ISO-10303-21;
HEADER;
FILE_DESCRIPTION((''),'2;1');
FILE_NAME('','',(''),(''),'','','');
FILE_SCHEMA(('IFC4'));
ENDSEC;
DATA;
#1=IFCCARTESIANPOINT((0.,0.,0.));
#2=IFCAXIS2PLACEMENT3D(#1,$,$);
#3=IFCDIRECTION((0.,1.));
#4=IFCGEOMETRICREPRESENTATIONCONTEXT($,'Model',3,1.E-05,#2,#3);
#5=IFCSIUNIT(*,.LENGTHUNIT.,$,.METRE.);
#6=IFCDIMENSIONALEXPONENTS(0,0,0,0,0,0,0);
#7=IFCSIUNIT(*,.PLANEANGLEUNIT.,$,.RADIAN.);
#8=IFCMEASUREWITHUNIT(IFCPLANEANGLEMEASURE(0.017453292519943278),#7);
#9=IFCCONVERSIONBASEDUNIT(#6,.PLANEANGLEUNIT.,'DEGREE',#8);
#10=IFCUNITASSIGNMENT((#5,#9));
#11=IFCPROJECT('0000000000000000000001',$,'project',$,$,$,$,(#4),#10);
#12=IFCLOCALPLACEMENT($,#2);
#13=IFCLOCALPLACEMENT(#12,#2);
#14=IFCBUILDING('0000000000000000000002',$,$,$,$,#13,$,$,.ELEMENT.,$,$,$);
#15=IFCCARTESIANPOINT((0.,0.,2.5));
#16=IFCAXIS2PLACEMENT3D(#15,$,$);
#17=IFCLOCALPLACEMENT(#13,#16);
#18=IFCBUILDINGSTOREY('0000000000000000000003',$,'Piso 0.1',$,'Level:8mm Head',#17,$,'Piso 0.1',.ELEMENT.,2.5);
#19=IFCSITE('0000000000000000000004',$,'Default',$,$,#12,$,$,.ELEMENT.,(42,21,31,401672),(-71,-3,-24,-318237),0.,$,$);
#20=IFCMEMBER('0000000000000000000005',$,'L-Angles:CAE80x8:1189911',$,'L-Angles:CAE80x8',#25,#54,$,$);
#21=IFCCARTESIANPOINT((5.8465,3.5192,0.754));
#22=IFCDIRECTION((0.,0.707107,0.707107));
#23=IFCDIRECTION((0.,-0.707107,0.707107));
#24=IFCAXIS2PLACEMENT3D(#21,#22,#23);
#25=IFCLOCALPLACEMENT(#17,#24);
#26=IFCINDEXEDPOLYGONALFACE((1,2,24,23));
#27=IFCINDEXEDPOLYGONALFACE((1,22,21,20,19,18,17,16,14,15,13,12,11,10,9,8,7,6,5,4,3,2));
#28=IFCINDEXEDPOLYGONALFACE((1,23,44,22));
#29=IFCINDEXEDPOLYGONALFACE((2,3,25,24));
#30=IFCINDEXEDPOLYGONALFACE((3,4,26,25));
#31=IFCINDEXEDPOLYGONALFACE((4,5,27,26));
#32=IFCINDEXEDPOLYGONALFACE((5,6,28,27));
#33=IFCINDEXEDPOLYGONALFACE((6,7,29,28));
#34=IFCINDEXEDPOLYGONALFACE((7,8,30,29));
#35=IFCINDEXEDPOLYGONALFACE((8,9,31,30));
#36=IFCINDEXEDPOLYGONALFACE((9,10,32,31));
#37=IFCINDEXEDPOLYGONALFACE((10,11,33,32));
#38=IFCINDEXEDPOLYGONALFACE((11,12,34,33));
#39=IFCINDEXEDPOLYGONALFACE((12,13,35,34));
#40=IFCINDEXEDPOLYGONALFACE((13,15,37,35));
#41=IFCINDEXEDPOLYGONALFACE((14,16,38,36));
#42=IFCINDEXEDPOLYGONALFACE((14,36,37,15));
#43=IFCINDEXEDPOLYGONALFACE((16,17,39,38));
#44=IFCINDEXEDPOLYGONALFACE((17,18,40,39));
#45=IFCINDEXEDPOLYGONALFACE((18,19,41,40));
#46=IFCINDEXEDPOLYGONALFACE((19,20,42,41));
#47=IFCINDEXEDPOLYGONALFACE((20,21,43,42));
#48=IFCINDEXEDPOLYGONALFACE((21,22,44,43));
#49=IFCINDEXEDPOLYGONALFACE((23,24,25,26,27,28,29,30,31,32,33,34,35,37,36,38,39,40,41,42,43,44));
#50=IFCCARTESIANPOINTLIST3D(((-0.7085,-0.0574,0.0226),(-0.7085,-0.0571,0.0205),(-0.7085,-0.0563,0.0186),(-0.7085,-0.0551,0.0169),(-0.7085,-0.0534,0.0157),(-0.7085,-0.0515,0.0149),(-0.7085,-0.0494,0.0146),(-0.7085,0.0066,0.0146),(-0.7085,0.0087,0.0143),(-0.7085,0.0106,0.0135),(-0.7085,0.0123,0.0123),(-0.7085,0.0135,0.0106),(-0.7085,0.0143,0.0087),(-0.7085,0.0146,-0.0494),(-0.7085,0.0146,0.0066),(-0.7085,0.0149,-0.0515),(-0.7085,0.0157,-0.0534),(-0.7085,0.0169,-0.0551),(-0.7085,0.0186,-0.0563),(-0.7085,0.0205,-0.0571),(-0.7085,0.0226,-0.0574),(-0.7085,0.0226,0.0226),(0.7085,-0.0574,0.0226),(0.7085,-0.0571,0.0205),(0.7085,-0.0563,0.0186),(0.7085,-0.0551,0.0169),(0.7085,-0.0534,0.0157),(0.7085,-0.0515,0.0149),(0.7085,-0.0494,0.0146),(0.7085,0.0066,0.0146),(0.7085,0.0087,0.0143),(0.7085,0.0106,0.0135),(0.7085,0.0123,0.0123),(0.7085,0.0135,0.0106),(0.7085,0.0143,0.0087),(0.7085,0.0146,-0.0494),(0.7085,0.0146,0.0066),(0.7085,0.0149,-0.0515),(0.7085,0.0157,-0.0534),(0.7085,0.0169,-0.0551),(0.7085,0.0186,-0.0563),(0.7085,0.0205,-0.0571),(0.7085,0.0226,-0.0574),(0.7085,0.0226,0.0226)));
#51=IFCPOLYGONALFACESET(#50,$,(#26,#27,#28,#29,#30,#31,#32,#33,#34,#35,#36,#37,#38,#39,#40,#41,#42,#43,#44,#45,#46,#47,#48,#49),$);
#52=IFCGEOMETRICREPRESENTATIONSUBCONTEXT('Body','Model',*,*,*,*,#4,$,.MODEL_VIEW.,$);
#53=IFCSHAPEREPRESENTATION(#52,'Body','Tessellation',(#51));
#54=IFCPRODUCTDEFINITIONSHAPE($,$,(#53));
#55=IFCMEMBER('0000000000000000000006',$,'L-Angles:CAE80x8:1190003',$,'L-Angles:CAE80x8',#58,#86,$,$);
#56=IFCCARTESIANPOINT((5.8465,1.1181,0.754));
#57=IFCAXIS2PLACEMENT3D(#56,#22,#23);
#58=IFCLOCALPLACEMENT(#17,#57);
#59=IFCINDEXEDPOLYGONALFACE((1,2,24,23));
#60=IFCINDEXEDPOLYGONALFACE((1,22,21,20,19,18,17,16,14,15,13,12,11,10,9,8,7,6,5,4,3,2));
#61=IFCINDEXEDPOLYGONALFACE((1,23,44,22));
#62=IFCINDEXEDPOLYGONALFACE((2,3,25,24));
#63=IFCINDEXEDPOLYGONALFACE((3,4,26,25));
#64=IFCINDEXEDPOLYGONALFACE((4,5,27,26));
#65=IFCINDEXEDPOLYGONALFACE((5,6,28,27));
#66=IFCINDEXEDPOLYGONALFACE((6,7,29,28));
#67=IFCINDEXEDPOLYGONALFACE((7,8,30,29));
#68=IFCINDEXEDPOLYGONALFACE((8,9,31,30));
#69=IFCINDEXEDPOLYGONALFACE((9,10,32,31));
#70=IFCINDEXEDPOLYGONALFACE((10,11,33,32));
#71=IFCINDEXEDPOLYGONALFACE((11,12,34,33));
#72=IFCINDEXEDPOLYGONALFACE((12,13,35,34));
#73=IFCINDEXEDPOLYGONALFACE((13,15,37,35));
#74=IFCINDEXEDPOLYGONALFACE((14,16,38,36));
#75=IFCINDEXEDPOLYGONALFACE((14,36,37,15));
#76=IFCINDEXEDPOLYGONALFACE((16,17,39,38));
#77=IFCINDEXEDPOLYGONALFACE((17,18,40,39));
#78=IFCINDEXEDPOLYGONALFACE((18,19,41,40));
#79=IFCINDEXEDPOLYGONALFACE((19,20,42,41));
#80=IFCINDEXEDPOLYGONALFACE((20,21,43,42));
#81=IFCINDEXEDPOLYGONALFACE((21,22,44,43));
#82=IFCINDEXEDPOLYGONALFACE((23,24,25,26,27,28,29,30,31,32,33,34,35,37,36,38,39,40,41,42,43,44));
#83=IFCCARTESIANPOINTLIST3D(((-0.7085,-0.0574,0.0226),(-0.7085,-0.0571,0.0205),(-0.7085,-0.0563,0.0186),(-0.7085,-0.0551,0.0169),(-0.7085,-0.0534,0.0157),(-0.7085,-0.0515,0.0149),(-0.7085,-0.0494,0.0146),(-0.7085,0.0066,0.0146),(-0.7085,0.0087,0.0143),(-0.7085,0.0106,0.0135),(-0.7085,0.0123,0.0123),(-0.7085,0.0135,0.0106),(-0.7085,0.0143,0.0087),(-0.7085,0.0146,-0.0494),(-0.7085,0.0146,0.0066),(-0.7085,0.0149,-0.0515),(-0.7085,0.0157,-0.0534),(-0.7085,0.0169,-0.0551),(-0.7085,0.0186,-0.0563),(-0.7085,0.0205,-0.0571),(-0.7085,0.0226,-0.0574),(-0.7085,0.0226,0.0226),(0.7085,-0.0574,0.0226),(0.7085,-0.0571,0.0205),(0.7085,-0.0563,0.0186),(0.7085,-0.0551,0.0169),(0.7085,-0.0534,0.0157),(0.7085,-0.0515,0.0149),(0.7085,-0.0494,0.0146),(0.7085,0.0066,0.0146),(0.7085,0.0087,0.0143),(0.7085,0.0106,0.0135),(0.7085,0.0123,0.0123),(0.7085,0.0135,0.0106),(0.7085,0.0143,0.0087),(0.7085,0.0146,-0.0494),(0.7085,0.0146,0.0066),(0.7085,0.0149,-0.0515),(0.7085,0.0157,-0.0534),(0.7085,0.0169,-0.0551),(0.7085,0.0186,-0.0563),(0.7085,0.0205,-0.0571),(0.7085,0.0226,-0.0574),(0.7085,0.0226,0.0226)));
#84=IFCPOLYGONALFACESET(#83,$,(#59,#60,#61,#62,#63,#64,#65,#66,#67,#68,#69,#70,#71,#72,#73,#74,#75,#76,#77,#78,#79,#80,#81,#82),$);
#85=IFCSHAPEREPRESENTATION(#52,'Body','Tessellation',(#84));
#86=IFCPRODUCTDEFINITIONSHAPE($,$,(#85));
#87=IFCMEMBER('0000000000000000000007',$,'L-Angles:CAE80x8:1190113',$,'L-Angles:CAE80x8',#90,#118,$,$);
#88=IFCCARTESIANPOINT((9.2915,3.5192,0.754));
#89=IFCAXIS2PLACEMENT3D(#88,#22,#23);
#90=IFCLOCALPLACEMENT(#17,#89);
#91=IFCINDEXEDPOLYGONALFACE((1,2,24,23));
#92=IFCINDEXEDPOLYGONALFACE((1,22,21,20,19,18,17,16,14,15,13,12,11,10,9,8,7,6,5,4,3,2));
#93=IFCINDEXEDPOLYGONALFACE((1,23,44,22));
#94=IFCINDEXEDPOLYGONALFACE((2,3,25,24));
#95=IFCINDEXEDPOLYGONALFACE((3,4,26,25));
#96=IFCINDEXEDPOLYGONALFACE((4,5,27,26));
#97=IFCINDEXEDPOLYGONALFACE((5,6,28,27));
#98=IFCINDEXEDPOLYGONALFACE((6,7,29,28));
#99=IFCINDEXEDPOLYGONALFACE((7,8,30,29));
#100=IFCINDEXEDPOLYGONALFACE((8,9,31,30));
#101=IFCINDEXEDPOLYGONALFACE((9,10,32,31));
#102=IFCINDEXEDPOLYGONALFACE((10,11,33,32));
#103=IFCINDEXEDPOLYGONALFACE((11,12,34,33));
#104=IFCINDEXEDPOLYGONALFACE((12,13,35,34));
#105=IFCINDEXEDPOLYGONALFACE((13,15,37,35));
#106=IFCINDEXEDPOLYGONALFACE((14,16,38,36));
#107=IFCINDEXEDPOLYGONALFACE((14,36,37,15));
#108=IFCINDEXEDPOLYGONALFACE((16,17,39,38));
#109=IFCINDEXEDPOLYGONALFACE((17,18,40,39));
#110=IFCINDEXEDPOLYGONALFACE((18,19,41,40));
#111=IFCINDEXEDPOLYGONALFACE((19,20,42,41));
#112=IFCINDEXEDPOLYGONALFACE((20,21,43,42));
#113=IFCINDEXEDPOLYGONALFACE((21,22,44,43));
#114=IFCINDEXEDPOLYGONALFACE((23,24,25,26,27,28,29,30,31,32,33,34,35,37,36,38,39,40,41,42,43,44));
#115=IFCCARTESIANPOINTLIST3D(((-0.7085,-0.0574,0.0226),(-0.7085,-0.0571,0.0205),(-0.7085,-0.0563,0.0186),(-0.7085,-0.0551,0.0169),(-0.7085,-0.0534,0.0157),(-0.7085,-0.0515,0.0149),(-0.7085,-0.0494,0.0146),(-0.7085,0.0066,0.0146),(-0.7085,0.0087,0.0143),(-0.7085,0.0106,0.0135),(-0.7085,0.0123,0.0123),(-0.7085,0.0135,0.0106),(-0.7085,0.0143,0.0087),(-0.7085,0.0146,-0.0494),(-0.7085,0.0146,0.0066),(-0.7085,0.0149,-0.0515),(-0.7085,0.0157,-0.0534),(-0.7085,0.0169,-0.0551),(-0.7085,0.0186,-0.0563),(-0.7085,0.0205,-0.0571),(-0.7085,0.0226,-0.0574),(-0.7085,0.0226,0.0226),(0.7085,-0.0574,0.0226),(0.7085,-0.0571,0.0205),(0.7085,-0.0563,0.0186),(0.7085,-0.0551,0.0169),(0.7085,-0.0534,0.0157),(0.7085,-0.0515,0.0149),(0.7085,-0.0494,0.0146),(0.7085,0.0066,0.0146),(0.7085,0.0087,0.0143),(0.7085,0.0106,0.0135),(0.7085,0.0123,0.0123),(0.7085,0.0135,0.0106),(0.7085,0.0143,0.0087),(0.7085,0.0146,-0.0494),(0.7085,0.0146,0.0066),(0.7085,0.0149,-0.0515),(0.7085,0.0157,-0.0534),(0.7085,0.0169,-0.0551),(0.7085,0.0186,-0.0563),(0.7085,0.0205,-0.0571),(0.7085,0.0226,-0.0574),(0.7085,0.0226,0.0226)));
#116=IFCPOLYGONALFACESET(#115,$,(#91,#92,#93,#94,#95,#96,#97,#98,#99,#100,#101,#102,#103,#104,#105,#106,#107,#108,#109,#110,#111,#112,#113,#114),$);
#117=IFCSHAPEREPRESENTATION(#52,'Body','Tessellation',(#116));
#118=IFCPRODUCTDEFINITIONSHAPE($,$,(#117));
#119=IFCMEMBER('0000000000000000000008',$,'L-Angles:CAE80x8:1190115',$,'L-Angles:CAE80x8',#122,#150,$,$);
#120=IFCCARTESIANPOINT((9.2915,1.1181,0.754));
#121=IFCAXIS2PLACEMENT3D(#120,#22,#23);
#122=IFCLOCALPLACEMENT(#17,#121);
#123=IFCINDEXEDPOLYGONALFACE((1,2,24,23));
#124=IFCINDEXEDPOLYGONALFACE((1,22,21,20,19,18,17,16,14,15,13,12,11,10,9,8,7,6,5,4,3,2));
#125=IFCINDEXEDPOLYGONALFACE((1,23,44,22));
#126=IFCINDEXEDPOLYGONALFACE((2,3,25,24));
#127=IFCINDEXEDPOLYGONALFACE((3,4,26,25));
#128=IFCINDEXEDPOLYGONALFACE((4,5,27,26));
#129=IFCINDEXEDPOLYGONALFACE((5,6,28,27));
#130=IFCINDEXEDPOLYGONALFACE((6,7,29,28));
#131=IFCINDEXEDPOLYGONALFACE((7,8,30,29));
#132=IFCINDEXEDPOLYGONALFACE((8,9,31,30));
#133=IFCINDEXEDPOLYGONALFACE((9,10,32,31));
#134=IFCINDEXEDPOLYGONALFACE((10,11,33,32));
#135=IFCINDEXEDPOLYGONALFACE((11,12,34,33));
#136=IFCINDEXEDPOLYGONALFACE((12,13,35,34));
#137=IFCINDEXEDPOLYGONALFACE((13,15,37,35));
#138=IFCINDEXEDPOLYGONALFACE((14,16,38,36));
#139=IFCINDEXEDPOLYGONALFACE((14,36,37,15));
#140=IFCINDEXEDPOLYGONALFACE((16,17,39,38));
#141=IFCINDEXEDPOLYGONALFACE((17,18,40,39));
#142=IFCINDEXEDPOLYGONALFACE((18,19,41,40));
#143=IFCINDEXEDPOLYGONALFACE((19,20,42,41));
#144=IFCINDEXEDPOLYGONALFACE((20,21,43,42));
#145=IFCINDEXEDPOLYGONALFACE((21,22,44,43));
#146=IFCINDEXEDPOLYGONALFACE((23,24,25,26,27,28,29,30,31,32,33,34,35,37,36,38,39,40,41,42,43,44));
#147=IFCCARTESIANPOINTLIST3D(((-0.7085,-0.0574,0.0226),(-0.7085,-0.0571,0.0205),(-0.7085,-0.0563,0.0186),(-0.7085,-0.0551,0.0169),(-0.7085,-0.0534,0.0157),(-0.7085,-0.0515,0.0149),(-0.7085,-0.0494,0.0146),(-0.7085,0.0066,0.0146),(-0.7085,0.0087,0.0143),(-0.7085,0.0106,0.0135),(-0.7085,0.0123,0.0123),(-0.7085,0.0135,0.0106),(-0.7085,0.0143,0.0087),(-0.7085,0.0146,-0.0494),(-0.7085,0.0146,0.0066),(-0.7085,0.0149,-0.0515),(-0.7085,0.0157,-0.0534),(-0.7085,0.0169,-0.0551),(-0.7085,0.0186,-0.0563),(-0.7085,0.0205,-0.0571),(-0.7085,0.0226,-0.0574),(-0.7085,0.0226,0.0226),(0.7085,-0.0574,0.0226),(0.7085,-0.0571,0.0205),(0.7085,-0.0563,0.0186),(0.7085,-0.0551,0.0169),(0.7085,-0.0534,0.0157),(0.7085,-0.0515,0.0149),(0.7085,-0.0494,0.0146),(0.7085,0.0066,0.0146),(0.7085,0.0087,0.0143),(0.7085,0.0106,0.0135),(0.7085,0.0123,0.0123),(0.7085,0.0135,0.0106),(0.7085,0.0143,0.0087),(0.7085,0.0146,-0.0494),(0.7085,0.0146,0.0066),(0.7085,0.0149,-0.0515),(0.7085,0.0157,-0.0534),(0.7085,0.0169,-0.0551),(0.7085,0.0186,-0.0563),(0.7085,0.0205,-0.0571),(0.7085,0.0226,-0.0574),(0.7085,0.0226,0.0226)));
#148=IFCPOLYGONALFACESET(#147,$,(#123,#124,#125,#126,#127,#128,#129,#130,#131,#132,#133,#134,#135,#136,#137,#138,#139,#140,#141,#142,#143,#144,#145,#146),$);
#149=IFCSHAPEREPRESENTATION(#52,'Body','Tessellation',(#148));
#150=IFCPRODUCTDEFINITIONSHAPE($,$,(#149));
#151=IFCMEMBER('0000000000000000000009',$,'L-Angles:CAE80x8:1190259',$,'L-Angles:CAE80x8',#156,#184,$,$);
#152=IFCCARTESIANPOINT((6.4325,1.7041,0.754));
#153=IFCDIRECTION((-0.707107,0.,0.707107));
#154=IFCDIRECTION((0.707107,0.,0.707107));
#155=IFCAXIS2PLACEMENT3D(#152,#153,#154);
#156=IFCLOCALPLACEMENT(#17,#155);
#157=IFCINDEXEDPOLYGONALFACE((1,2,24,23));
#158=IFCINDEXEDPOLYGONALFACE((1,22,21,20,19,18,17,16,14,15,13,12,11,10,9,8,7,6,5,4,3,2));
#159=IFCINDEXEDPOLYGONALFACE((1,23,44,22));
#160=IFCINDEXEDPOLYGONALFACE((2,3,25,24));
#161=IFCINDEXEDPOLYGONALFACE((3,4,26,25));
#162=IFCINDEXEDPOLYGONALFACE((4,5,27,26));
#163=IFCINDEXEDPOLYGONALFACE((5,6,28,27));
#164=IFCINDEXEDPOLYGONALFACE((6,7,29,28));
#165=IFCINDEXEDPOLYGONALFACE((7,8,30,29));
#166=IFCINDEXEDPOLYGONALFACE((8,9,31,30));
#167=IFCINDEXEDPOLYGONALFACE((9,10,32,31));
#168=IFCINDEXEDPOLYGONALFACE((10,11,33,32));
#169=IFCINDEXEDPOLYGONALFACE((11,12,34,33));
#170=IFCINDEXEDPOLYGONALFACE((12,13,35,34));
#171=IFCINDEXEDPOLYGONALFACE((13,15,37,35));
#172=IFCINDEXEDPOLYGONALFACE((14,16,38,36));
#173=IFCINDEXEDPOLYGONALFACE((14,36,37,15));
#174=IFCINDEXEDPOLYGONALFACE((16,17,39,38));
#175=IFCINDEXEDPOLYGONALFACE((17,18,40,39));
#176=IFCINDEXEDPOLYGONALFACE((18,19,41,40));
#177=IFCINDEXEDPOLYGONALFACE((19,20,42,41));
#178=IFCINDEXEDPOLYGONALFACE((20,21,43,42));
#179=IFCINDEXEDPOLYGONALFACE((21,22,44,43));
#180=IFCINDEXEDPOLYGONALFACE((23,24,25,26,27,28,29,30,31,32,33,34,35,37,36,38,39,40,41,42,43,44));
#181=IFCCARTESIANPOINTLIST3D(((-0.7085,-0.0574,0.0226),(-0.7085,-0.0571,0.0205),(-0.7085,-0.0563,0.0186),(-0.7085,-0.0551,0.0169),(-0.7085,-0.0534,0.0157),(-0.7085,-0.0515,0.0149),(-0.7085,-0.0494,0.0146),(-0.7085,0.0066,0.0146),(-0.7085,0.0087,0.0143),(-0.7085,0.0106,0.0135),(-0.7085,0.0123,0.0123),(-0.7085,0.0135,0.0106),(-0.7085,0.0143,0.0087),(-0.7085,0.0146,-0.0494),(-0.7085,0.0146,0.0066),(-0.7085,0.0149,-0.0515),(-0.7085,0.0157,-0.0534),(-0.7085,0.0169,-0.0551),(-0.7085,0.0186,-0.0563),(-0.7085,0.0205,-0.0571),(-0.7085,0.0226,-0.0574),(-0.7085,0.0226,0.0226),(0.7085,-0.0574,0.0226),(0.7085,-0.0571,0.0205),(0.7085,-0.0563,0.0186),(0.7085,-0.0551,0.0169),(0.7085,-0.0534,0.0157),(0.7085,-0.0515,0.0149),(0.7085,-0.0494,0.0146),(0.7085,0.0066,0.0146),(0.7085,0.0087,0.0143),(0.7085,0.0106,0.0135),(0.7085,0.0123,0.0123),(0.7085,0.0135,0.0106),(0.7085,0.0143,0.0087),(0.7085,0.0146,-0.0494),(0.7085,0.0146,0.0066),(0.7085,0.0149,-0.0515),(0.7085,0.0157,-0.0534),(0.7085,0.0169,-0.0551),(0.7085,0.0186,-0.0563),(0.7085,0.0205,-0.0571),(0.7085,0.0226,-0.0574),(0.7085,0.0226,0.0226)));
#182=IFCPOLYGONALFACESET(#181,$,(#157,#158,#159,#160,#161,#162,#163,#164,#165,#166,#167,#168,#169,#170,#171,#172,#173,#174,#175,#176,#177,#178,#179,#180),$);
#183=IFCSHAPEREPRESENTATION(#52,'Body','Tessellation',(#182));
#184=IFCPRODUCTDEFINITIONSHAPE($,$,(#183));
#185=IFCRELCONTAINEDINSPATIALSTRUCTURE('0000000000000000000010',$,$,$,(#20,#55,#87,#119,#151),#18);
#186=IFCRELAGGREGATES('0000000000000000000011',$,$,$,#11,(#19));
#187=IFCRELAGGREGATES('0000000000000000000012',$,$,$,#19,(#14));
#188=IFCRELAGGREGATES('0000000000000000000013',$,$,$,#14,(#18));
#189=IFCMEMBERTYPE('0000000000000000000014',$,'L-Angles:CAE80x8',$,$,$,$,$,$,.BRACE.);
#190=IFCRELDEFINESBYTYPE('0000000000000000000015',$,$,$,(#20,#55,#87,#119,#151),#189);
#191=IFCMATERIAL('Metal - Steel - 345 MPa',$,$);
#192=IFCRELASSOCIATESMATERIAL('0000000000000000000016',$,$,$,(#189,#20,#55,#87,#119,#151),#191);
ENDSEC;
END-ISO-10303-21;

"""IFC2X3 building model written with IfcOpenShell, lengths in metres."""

from ifc_helpers import new_model, entity, si_unit, converted_unit, direction, frame, frame_2d, origin, place, context, subcontext, project, spatial, polyline, circle_curve, parameter, trimmed, segment, composite_curve, outline, extrude, source, transform, mapped, material, type_object, type_shapes, element, save


model = new_model("IFC2X3")

# Units and contexts
model_context = context("Model", 3, precision=1e-05, world=origin(), true_north=direction((0.0, 1.0)))
body_context = subcontext(model_context, "Body", "Model", "MODEL_VIEW")
ifc_project = project(units=[si_unit("LENGTHUNIT", "METRE"), converted_unit("PLANEANGLEUNIT", "DEGREE", entity("IfcPlaneAngleMeasure", 0.017453292519943278), si_unit("PLANEANGLEUNIT", "RADIAN"), dimensions=[0, 0, 0, 0, 0, 0, 0])], contexts=[model_context])

# Site, building, storey
site_placement = place(None, origin())
site = spatial("IfcSite", under=ifc_project, at=site_placement, Name="Default", CompositionType="ELEMENT", RefLatitude=(42, 21, 31, 401672), RefLongitude=(-71, -3, -24, -318237), RefElevation=0.0)
building_placement = place(site_placement, origin())
building = spatial("IfcBuilding", under=site, at=building_placement, CompositionType="ELEMENT")
storey_placement = place(building_placement, frame((0.0, 0.0, 2.5)))
storey = spatial("IfcBuildingStorey", under=building, at=storey_placement, Name="Piso 0.1", ObjectType="Level:8mm Head", LongName="Piso 0.1", CompositionType="ELEMENT", Elevation=2.5)

# Members
ifc_material = material(Name="Metal - Steel - 345 MPa")
member_type_1 = type_object("IfcMemberType", Name="L-Angles:CAE80x8", PredefinedType="BRACE", material=ifc_material)
shared_shape_1 = source(origin(), body_context, "Body", "SweptSolid", [
    extrude(outline(composite_curve([segment(polyline([(-0.0263, -0.0263), (0.0537, -0.0263)]), True, "CONTINUOUS"), segment(trimmed(circle_curve(frame_2d((0.0457, -0.0263), x_axis=(1.0, 0.0)), 0.008), [parameter(0.0)], [parameter(90.0)], True, "PARAMETER"), True, "CONTINUOUS"), segment(polyline([(0.0457, -0.0183), (-0.0103, -0.0183)]), True, "CONTINUOUS"), segment(trimmed(circle_curve(frame_2d((-0.0103, -0.0103), x_axis=(1.0, 0.0)), 0.008), [parameter(180.0)], [parameter(270.0)], True, "PARAMETER"), False, "CONTINUOUS"), segment(polyline([(-0.0183, -0.0103), (-0.0183, 0.0457)]), True, "CONTINUOUS"), segment(trimmed(circle_curve(frame_2d((-0.0263, 0.0457), x_axis=(1.0, 0.0)), 0.008), [parameter(0.0)], [parameter(90.0)], True, "PARAMETER"), True, "CONTINUOUS"), segment(polyline([(-0.0263, 0.0537), (-0.0263, -0.0263)]), True, "CONTINUOUS")], self_intersect=False)), frame((-0.7085, -0.0037, -0.0037), z_axis=(1.0, 0.0, 0.0), x_axis=(0.0, -1.0, 0.0)), (0.0, 0.0, 1.0), 1.417),
])
type_shapes(member_type_1, [shared_shape_1])
for number, where, z_axis, x_axis, name in (
    (1, (5.8465, 3.5192, 0.754), (0.0, 0.707107, 0.707107), (0.0, -0.707107, 0.707107), "L-Angles:CAE80x8:1189911"),
    (2, (5.8465, 1.1181, 0.754), (0.0, 0.707107, 0.707107), (0.0, -0.707107, 0.707107), "L-Angles:CAE80x8:1190003"),
    (3, (9.2915, 3.5192, 0.754), (0.0, 0.707107, 0.707107), (0.0, -0.707107, 0.707107), "L-Angles:CAE80x8:1190113"),
    (4, (9.2915, 1.1181, 0.754), (0.0, 0.707107, 0.707107), (0.0, -0.707107, 0.707107), "L-Angles:CAE80x8:1190115"),
    (5, (6.4325, 1.7041, 0.754), (-0.707107, 0.0, 0.707107), (0.707107, 0.0, 0.707107), "L-Angles:CAE80x8:1190259"),
):
    element("IfcMember", number, at=place(storey_placement, frame(where, z_axis=z_axis, x_axis=x_axis)), inside=storey, type_object=member_type_1, material=ifc_material, Name=name, ObjectType="L-Angles:CAE80x8", context=body_context, shape_type="MappedRepresentation", body=[
        mapped(shared_shape_1, transform((0.0, 0.0, 0.0), scale=1.0)),
    ])

save(model, "model.ifc")
